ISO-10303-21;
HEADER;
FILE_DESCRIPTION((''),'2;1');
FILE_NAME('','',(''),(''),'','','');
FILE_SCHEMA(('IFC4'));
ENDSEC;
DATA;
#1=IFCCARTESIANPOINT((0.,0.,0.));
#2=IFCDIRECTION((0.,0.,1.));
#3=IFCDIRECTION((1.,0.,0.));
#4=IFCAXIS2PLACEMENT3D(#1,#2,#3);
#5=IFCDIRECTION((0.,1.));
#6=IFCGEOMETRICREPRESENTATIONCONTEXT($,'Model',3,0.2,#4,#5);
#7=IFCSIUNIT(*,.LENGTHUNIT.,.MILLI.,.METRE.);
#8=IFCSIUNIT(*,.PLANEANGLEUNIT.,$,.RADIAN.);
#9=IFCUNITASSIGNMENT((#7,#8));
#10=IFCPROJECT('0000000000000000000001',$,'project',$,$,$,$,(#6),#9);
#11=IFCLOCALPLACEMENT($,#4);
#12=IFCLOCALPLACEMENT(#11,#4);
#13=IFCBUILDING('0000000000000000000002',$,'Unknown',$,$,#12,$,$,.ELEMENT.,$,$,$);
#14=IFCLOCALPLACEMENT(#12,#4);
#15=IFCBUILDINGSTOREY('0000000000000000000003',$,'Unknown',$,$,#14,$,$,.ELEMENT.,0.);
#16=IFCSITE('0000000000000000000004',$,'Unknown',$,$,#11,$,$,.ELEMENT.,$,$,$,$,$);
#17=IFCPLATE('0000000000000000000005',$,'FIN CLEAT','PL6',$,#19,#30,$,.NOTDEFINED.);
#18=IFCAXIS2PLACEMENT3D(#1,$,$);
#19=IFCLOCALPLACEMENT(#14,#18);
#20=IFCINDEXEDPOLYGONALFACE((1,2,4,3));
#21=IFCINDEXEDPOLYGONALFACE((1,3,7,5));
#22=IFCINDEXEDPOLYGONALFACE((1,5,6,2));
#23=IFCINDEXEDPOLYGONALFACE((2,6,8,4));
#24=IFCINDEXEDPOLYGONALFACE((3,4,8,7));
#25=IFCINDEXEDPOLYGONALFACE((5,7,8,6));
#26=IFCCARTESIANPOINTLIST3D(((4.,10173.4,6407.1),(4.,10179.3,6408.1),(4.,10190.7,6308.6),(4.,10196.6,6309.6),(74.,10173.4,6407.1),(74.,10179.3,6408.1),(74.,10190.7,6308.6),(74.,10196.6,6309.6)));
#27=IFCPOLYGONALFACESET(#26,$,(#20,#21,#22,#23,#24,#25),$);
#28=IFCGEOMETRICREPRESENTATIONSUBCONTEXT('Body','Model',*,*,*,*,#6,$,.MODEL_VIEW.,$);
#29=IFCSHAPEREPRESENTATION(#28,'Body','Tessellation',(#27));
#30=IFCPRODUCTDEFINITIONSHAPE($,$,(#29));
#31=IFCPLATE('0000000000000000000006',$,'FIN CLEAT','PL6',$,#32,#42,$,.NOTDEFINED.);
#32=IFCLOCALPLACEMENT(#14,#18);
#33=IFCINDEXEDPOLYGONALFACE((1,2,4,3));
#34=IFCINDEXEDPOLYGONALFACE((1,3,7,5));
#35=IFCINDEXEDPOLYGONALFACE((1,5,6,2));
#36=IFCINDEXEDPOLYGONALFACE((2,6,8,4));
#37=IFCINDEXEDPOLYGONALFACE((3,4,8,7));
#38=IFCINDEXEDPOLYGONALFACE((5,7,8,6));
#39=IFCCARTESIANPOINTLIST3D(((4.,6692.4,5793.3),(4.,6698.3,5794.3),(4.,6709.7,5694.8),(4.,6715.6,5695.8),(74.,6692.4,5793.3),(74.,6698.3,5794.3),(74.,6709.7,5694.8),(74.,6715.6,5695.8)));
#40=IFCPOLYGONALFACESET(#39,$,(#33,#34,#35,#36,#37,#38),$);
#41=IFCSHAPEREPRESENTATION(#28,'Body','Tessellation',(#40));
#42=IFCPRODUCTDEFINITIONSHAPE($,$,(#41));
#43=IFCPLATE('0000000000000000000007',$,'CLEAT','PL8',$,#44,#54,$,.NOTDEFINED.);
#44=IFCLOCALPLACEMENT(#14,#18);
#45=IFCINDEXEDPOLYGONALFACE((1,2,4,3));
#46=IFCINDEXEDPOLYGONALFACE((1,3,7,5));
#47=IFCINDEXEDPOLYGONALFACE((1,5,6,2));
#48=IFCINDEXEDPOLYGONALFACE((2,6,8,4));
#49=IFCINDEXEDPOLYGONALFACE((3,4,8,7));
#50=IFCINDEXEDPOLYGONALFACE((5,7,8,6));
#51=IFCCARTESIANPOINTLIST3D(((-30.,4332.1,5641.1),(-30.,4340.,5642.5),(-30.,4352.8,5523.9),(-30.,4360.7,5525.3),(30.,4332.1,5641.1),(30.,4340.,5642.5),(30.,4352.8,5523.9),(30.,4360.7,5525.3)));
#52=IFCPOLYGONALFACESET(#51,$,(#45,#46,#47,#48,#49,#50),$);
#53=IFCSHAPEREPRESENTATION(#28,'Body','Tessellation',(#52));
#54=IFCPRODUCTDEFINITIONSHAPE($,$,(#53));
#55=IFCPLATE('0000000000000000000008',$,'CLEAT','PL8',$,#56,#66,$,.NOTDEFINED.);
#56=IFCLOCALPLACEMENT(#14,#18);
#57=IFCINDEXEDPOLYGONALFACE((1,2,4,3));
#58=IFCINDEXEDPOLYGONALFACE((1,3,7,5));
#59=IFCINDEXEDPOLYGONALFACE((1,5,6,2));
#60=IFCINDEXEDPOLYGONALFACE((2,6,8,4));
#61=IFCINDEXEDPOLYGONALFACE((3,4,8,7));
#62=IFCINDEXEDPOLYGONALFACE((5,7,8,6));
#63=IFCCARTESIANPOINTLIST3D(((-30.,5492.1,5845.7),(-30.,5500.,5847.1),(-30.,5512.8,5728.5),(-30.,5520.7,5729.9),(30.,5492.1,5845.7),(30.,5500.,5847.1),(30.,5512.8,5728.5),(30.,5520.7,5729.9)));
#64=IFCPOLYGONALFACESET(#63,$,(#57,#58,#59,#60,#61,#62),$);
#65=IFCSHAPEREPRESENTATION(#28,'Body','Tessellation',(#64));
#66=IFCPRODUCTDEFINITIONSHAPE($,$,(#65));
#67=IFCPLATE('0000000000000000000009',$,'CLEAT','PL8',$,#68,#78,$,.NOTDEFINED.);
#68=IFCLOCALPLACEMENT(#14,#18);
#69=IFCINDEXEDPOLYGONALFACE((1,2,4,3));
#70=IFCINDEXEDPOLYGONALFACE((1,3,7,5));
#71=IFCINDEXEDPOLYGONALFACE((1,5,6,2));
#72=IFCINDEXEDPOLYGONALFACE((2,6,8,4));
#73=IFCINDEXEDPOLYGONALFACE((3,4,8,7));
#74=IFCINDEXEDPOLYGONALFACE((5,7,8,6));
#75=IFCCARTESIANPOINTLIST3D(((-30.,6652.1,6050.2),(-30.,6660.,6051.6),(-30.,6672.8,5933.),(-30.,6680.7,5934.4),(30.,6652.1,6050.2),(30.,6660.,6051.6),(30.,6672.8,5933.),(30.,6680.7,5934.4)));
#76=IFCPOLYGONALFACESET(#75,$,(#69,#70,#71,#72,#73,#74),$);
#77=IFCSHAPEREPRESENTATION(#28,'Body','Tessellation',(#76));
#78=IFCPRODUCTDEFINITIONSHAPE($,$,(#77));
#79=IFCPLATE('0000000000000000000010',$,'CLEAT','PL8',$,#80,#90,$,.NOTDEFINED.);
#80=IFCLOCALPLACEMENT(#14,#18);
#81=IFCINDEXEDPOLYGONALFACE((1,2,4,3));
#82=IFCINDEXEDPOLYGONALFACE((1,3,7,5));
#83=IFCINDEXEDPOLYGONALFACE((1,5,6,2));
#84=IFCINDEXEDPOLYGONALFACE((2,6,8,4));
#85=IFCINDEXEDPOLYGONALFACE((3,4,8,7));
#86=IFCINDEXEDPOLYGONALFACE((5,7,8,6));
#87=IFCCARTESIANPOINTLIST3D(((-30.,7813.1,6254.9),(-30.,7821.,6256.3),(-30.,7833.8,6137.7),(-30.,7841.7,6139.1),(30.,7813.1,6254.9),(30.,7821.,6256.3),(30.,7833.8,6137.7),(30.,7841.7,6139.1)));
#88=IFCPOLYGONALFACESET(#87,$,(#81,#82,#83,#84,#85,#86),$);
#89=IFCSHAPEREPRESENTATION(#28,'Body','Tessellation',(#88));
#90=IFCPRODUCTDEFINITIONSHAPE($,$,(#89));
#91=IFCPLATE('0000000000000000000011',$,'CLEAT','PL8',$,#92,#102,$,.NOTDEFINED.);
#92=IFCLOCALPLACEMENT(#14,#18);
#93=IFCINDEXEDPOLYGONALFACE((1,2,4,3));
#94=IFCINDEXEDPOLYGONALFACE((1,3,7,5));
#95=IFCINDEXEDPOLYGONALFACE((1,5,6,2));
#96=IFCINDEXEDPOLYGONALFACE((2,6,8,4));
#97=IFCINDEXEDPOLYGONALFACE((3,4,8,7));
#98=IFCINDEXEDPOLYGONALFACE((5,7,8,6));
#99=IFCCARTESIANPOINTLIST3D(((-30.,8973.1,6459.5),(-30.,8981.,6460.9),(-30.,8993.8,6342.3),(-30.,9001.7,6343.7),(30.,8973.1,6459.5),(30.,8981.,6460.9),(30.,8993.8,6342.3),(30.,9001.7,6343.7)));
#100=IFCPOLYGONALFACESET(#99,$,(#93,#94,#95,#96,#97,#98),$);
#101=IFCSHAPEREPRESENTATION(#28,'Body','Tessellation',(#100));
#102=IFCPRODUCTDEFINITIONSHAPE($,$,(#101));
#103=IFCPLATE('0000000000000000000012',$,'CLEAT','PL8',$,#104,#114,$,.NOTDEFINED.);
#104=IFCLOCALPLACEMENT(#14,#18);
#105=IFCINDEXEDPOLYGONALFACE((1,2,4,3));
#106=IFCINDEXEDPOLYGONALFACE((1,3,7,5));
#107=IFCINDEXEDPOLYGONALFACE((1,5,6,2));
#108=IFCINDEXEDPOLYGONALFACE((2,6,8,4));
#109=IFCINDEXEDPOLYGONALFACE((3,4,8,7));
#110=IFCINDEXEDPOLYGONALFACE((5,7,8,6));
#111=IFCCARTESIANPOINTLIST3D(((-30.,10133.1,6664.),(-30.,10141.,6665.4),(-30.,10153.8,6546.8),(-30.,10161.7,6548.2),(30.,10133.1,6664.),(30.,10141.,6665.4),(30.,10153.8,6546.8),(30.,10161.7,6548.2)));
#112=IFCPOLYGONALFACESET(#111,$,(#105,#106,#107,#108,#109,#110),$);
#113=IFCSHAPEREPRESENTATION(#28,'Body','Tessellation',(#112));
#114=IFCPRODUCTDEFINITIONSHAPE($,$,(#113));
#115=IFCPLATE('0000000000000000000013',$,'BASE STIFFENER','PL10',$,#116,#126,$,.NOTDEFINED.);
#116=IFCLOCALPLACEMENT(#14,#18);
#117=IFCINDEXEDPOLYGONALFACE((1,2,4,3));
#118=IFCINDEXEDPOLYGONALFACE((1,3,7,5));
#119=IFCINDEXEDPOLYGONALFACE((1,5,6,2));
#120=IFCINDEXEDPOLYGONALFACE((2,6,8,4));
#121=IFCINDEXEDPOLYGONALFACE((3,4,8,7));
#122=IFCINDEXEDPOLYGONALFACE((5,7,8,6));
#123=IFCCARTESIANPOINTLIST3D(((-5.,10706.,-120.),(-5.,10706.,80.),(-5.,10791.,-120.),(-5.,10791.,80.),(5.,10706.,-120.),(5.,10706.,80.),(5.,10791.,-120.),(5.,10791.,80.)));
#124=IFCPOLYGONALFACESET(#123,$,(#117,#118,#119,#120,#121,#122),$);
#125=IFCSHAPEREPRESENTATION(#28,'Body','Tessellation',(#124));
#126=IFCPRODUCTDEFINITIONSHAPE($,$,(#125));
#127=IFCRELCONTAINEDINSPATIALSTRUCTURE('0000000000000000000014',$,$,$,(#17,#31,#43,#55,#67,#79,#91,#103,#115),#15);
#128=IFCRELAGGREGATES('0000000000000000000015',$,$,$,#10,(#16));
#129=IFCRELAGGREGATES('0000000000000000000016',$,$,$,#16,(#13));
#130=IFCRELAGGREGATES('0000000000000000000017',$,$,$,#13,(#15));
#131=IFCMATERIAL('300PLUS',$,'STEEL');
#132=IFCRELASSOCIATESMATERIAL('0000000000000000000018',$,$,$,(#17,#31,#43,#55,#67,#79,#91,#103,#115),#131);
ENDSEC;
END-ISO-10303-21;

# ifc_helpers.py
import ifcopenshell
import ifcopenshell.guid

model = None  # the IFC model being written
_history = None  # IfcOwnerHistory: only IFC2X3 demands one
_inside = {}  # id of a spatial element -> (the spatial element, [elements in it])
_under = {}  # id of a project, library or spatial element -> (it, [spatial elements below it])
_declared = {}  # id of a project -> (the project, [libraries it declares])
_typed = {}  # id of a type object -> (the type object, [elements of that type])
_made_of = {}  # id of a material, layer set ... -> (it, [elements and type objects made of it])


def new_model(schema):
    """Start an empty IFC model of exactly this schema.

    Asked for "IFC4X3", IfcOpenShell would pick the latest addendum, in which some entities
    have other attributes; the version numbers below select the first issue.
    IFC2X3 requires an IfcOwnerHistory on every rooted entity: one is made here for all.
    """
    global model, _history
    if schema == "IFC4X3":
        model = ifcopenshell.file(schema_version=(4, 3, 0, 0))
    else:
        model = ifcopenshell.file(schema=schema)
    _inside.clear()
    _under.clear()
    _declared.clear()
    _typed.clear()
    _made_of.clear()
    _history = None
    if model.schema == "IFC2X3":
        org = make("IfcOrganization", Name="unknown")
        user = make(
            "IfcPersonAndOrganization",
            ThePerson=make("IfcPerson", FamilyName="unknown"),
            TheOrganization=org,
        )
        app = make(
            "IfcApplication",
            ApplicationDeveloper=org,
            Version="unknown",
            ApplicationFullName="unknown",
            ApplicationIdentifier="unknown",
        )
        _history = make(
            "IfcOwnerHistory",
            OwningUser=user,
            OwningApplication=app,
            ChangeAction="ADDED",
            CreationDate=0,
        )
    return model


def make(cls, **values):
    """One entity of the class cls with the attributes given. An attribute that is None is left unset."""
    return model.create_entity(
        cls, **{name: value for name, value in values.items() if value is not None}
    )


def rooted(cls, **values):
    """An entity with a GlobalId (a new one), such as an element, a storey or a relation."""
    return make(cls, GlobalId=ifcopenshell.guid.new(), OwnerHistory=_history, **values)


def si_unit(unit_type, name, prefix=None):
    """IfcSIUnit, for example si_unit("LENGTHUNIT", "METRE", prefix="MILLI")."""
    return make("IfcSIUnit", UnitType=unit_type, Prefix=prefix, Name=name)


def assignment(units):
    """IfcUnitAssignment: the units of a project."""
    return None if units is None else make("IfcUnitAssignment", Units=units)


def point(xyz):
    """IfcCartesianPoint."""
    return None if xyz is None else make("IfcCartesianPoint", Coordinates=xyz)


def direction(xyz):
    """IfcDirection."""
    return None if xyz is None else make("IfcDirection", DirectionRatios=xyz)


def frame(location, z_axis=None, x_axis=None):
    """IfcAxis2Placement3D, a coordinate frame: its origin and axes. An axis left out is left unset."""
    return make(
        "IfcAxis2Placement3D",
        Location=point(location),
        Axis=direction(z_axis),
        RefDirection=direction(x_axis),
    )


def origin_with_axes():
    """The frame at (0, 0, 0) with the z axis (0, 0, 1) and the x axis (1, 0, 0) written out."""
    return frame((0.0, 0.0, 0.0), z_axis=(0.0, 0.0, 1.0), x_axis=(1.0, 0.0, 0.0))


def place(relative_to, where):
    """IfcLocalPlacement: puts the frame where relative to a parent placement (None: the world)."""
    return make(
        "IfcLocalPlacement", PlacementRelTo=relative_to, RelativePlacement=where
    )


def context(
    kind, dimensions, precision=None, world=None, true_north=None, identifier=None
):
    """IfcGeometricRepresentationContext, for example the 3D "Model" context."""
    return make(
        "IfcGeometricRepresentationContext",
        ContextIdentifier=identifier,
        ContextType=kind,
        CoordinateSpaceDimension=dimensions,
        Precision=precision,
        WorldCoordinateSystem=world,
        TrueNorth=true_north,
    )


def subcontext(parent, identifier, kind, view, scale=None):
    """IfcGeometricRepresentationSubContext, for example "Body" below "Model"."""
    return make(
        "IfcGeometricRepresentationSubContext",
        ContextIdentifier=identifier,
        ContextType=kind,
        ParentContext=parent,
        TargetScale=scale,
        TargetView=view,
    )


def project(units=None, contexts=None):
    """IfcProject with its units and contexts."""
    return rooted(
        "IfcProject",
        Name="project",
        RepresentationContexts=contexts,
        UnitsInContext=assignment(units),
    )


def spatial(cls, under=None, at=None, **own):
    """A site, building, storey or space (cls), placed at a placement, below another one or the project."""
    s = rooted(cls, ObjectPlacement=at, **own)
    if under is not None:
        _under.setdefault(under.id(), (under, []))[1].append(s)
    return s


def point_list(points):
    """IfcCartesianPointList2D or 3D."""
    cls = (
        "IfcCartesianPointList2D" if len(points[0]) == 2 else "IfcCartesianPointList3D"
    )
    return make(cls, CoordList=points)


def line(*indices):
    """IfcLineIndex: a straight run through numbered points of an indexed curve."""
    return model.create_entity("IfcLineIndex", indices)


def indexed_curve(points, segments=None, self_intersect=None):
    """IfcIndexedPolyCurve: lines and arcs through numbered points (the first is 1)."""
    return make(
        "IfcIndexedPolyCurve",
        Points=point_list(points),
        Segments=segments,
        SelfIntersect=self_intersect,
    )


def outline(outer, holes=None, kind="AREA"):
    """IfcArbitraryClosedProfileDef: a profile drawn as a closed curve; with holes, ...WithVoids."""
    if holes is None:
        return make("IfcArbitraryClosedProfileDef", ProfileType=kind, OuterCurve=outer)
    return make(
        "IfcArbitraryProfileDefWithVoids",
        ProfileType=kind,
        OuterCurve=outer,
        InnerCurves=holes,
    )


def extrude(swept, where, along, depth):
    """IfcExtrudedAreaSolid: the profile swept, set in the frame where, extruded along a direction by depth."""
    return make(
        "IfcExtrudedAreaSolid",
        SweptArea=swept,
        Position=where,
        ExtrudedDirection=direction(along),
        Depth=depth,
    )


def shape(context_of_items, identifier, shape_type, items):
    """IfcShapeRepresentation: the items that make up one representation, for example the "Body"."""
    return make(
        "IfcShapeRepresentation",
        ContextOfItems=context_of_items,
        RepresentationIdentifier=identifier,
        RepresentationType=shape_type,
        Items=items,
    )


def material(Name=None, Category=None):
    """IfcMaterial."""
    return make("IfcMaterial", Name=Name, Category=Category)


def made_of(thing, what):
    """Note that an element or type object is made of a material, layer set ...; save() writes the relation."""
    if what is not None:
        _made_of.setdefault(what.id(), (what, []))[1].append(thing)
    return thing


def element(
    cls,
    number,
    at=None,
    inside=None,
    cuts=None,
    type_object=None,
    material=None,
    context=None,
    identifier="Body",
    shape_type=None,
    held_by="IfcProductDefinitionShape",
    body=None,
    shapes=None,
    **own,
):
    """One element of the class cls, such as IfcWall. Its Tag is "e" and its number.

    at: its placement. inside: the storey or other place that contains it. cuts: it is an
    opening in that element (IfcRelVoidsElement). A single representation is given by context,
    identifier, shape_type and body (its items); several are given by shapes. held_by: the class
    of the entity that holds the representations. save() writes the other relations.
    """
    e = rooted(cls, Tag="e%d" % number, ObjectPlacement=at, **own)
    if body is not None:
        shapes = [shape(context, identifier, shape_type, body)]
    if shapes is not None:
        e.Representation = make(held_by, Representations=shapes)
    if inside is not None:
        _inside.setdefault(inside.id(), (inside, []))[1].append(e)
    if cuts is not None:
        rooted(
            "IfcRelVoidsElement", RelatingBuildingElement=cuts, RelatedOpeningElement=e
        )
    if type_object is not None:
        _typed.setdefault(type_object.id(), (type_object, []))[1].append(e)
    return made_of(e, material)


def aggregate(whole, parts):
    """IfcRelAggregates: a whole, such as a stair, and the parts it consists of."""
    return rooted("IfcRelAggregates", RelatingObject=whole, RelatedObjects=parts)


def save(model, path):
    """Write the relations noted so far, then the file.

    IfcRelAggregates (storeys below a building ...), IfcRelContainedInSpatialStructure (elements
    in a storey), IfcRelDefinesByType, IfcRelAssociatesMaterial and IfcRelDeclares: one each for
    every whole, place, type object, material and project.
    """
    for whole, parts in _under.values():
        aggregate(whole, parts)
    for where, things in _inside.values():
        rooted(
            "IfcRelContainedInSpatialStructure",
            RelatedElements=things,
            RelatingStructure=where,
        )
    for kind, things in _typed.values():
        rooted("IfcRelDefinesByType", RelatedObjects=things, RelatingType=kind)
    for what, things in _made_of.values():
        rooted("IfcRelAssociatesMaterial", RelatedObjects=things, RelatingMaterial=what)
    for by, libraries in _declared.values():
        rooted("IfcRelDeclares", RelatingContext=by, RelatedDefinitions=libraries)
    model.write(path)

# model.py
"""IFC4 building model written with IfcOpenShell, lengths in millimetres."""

from ifc_helpers import new_model, si_unit, direction, frame, origin_with_axes, place, context, subcontext, project, spatial, line, indexed_curve, outline, extrude, material, element, save


model = new_model("IFC4")

# Units and contexts
model_context = context("Model", 3, precision=0.2, world=origin_with_axes(), true_north=direction((0.0, 1.0)))
body_context = subcontext(model_context, "Body", "Model", "MODEL_VIEW")
ifc_project = project(units=[si_unit("LENGTHUNIT", "METRE", prefix="MILLI"), si_unit("PLANEANGLEUNIT", "RADIAN")], contexts=[model_context])

# Site, building, storey
site_placement = place(None, origin_with_axes())
site = spatial("IfcSite", under=ifc_project, at=site_placement, Name="Unknown", CompositionType="ELEMENT")
building_placement = place(site_placement, origin_with_axes())
building = spatial("IfcBuilding", under=site, at=building_placement, Name="Unknown", CompositionType="ELEMENT")
storey_placement = place(building_placement, origin_with_axes())
storey = spatial("IfcBuildingStorey", under=building, at=storey_placement, Name="Unknown", CompositionType="ELEMENT", Elevation=0.0)

# Shared definitions
ifc_material_1 = material(Name="300PLUS", Category="STEEL")

# Plates
for number, where, z_axis, x_axis, name in (
    (1, (4.0, 10176.4, 6407.6), (0.0, 0.984924, 0.172987), (1.0, 0.0, 0.0), "FIN CLEAT"),
    (2, (4.0, 6695.4, 5793.8), (0.0, 0.984924, 0.172987), (1.0, 0.0, 0.0), "FIN CLEAT"),
):
    element("IfcPlate", number, at=place(storey_placement, frame(where, z_axis=z_axis, x_axis=x_axis)), inside=storey, material=ifc_material_1, Name=name, Description="PL6", PredefinedType="NOTDEFINED", context=body_context, shape_type="SolidModel", body=[
        extrude(outline(indexed_curve([(0.0, 0.0), (70.0, 0.0), (70.0, 100.0), (0.0, 100.0)], segments=[line(1, 2, 3, 4, 1)])), frame((0.0, 0.0, 3.0), z_axis=(0.0, 0.0, 1.0), x_axis=(1.0, 0.0, 0.0)), (0.0, 0.0, -1.0), 6.0),
    ])
for number, where, z_axis, x_axis, name in (
    (3, (30.0, 4356.7, 5524.6), (0.0, 0.984758, 0.173929), (-1.0, 0.0, 0.0), "CLEAT"),
    (4, (30.0, 5516.7, 5729.2), (0.0, 0.984758, 0.173929), (-1.0, 0.0, 0.0), "CLEAT"),
    (5, (30.0, 6676.7, 5933.7), (0.0, 0.984758, 0.173929), (-1.0, 0.0, 0.0), "CLEAT"),
    (6, (30.0, 7837.7, 6138.4), (0.0, 0.984758, 0.173929), (-1.0, 0.0, 0.0), "CLEAT"),
    (7, (30.0, 8997.7, 6343.0), (0.0, 0.984758, 0.173929), (-1.0, 0.0, 0.0), "CLEAT"),
    (8, (30.0, 10157.7, 6547.5), (0.0, 0.984758, 0.173929), (-1.0, 0.0, 0.0), "CLEAT"),
):
    element("IfcPlate", number, at=place(storey_placement, frame(where, z_axis=z_axis, x_axis=x_axis)), inside=storey, material=ifc_material_1, Name=name, Description="PL8", PredefinedType="NOTDEFINED", context=body_context, shape_type="SolidModel", body=[
        extrude(outline(indexed_curve([(0.0, 0.0), (60.0, 0.0), (60.0, 119.0), (0.0, 119.0)], segments=[line(1, 2, 3, 4, 1)])), frame((0.0, 0.0, 4.0), z_axis=(0.0, 0.0, 1.0), x_axis=(1.0, 0.0, 0.0)), (0.0, 0.0, -1.0), 8.0),
    ])
plate_placement = place(storey_placement, frame((0.0, 10706.0, -120.0), z_axis=(1.0, 0.0, 0.0), x_axis=(0.0, 1.0, 0.0)))
element("IfcPlate", 9, at=plate_placement, inside=storey, material=ifc_material_1, Name="BASE STIFFENER", Description="PL10", PredefinedType="NOTDEFINED", context=body_context, shape_type="SolidModel", body=[
    extrude(outline(indexed_curve([(0.0, 0.0), (85.0, 0.0), (85.0, 200.0), (0.0, 200.0)], segments=[line(1, 2, 3, 4, 1)])), frame((0.0, 0.0, 5.0), z_axis=(0.0, 0.0, 1.0), x_axis=(1.0, 0.0, 0.0)), (0.0, 0.0, -1.0), 10.0),
])

save(model, "model.ifc")
